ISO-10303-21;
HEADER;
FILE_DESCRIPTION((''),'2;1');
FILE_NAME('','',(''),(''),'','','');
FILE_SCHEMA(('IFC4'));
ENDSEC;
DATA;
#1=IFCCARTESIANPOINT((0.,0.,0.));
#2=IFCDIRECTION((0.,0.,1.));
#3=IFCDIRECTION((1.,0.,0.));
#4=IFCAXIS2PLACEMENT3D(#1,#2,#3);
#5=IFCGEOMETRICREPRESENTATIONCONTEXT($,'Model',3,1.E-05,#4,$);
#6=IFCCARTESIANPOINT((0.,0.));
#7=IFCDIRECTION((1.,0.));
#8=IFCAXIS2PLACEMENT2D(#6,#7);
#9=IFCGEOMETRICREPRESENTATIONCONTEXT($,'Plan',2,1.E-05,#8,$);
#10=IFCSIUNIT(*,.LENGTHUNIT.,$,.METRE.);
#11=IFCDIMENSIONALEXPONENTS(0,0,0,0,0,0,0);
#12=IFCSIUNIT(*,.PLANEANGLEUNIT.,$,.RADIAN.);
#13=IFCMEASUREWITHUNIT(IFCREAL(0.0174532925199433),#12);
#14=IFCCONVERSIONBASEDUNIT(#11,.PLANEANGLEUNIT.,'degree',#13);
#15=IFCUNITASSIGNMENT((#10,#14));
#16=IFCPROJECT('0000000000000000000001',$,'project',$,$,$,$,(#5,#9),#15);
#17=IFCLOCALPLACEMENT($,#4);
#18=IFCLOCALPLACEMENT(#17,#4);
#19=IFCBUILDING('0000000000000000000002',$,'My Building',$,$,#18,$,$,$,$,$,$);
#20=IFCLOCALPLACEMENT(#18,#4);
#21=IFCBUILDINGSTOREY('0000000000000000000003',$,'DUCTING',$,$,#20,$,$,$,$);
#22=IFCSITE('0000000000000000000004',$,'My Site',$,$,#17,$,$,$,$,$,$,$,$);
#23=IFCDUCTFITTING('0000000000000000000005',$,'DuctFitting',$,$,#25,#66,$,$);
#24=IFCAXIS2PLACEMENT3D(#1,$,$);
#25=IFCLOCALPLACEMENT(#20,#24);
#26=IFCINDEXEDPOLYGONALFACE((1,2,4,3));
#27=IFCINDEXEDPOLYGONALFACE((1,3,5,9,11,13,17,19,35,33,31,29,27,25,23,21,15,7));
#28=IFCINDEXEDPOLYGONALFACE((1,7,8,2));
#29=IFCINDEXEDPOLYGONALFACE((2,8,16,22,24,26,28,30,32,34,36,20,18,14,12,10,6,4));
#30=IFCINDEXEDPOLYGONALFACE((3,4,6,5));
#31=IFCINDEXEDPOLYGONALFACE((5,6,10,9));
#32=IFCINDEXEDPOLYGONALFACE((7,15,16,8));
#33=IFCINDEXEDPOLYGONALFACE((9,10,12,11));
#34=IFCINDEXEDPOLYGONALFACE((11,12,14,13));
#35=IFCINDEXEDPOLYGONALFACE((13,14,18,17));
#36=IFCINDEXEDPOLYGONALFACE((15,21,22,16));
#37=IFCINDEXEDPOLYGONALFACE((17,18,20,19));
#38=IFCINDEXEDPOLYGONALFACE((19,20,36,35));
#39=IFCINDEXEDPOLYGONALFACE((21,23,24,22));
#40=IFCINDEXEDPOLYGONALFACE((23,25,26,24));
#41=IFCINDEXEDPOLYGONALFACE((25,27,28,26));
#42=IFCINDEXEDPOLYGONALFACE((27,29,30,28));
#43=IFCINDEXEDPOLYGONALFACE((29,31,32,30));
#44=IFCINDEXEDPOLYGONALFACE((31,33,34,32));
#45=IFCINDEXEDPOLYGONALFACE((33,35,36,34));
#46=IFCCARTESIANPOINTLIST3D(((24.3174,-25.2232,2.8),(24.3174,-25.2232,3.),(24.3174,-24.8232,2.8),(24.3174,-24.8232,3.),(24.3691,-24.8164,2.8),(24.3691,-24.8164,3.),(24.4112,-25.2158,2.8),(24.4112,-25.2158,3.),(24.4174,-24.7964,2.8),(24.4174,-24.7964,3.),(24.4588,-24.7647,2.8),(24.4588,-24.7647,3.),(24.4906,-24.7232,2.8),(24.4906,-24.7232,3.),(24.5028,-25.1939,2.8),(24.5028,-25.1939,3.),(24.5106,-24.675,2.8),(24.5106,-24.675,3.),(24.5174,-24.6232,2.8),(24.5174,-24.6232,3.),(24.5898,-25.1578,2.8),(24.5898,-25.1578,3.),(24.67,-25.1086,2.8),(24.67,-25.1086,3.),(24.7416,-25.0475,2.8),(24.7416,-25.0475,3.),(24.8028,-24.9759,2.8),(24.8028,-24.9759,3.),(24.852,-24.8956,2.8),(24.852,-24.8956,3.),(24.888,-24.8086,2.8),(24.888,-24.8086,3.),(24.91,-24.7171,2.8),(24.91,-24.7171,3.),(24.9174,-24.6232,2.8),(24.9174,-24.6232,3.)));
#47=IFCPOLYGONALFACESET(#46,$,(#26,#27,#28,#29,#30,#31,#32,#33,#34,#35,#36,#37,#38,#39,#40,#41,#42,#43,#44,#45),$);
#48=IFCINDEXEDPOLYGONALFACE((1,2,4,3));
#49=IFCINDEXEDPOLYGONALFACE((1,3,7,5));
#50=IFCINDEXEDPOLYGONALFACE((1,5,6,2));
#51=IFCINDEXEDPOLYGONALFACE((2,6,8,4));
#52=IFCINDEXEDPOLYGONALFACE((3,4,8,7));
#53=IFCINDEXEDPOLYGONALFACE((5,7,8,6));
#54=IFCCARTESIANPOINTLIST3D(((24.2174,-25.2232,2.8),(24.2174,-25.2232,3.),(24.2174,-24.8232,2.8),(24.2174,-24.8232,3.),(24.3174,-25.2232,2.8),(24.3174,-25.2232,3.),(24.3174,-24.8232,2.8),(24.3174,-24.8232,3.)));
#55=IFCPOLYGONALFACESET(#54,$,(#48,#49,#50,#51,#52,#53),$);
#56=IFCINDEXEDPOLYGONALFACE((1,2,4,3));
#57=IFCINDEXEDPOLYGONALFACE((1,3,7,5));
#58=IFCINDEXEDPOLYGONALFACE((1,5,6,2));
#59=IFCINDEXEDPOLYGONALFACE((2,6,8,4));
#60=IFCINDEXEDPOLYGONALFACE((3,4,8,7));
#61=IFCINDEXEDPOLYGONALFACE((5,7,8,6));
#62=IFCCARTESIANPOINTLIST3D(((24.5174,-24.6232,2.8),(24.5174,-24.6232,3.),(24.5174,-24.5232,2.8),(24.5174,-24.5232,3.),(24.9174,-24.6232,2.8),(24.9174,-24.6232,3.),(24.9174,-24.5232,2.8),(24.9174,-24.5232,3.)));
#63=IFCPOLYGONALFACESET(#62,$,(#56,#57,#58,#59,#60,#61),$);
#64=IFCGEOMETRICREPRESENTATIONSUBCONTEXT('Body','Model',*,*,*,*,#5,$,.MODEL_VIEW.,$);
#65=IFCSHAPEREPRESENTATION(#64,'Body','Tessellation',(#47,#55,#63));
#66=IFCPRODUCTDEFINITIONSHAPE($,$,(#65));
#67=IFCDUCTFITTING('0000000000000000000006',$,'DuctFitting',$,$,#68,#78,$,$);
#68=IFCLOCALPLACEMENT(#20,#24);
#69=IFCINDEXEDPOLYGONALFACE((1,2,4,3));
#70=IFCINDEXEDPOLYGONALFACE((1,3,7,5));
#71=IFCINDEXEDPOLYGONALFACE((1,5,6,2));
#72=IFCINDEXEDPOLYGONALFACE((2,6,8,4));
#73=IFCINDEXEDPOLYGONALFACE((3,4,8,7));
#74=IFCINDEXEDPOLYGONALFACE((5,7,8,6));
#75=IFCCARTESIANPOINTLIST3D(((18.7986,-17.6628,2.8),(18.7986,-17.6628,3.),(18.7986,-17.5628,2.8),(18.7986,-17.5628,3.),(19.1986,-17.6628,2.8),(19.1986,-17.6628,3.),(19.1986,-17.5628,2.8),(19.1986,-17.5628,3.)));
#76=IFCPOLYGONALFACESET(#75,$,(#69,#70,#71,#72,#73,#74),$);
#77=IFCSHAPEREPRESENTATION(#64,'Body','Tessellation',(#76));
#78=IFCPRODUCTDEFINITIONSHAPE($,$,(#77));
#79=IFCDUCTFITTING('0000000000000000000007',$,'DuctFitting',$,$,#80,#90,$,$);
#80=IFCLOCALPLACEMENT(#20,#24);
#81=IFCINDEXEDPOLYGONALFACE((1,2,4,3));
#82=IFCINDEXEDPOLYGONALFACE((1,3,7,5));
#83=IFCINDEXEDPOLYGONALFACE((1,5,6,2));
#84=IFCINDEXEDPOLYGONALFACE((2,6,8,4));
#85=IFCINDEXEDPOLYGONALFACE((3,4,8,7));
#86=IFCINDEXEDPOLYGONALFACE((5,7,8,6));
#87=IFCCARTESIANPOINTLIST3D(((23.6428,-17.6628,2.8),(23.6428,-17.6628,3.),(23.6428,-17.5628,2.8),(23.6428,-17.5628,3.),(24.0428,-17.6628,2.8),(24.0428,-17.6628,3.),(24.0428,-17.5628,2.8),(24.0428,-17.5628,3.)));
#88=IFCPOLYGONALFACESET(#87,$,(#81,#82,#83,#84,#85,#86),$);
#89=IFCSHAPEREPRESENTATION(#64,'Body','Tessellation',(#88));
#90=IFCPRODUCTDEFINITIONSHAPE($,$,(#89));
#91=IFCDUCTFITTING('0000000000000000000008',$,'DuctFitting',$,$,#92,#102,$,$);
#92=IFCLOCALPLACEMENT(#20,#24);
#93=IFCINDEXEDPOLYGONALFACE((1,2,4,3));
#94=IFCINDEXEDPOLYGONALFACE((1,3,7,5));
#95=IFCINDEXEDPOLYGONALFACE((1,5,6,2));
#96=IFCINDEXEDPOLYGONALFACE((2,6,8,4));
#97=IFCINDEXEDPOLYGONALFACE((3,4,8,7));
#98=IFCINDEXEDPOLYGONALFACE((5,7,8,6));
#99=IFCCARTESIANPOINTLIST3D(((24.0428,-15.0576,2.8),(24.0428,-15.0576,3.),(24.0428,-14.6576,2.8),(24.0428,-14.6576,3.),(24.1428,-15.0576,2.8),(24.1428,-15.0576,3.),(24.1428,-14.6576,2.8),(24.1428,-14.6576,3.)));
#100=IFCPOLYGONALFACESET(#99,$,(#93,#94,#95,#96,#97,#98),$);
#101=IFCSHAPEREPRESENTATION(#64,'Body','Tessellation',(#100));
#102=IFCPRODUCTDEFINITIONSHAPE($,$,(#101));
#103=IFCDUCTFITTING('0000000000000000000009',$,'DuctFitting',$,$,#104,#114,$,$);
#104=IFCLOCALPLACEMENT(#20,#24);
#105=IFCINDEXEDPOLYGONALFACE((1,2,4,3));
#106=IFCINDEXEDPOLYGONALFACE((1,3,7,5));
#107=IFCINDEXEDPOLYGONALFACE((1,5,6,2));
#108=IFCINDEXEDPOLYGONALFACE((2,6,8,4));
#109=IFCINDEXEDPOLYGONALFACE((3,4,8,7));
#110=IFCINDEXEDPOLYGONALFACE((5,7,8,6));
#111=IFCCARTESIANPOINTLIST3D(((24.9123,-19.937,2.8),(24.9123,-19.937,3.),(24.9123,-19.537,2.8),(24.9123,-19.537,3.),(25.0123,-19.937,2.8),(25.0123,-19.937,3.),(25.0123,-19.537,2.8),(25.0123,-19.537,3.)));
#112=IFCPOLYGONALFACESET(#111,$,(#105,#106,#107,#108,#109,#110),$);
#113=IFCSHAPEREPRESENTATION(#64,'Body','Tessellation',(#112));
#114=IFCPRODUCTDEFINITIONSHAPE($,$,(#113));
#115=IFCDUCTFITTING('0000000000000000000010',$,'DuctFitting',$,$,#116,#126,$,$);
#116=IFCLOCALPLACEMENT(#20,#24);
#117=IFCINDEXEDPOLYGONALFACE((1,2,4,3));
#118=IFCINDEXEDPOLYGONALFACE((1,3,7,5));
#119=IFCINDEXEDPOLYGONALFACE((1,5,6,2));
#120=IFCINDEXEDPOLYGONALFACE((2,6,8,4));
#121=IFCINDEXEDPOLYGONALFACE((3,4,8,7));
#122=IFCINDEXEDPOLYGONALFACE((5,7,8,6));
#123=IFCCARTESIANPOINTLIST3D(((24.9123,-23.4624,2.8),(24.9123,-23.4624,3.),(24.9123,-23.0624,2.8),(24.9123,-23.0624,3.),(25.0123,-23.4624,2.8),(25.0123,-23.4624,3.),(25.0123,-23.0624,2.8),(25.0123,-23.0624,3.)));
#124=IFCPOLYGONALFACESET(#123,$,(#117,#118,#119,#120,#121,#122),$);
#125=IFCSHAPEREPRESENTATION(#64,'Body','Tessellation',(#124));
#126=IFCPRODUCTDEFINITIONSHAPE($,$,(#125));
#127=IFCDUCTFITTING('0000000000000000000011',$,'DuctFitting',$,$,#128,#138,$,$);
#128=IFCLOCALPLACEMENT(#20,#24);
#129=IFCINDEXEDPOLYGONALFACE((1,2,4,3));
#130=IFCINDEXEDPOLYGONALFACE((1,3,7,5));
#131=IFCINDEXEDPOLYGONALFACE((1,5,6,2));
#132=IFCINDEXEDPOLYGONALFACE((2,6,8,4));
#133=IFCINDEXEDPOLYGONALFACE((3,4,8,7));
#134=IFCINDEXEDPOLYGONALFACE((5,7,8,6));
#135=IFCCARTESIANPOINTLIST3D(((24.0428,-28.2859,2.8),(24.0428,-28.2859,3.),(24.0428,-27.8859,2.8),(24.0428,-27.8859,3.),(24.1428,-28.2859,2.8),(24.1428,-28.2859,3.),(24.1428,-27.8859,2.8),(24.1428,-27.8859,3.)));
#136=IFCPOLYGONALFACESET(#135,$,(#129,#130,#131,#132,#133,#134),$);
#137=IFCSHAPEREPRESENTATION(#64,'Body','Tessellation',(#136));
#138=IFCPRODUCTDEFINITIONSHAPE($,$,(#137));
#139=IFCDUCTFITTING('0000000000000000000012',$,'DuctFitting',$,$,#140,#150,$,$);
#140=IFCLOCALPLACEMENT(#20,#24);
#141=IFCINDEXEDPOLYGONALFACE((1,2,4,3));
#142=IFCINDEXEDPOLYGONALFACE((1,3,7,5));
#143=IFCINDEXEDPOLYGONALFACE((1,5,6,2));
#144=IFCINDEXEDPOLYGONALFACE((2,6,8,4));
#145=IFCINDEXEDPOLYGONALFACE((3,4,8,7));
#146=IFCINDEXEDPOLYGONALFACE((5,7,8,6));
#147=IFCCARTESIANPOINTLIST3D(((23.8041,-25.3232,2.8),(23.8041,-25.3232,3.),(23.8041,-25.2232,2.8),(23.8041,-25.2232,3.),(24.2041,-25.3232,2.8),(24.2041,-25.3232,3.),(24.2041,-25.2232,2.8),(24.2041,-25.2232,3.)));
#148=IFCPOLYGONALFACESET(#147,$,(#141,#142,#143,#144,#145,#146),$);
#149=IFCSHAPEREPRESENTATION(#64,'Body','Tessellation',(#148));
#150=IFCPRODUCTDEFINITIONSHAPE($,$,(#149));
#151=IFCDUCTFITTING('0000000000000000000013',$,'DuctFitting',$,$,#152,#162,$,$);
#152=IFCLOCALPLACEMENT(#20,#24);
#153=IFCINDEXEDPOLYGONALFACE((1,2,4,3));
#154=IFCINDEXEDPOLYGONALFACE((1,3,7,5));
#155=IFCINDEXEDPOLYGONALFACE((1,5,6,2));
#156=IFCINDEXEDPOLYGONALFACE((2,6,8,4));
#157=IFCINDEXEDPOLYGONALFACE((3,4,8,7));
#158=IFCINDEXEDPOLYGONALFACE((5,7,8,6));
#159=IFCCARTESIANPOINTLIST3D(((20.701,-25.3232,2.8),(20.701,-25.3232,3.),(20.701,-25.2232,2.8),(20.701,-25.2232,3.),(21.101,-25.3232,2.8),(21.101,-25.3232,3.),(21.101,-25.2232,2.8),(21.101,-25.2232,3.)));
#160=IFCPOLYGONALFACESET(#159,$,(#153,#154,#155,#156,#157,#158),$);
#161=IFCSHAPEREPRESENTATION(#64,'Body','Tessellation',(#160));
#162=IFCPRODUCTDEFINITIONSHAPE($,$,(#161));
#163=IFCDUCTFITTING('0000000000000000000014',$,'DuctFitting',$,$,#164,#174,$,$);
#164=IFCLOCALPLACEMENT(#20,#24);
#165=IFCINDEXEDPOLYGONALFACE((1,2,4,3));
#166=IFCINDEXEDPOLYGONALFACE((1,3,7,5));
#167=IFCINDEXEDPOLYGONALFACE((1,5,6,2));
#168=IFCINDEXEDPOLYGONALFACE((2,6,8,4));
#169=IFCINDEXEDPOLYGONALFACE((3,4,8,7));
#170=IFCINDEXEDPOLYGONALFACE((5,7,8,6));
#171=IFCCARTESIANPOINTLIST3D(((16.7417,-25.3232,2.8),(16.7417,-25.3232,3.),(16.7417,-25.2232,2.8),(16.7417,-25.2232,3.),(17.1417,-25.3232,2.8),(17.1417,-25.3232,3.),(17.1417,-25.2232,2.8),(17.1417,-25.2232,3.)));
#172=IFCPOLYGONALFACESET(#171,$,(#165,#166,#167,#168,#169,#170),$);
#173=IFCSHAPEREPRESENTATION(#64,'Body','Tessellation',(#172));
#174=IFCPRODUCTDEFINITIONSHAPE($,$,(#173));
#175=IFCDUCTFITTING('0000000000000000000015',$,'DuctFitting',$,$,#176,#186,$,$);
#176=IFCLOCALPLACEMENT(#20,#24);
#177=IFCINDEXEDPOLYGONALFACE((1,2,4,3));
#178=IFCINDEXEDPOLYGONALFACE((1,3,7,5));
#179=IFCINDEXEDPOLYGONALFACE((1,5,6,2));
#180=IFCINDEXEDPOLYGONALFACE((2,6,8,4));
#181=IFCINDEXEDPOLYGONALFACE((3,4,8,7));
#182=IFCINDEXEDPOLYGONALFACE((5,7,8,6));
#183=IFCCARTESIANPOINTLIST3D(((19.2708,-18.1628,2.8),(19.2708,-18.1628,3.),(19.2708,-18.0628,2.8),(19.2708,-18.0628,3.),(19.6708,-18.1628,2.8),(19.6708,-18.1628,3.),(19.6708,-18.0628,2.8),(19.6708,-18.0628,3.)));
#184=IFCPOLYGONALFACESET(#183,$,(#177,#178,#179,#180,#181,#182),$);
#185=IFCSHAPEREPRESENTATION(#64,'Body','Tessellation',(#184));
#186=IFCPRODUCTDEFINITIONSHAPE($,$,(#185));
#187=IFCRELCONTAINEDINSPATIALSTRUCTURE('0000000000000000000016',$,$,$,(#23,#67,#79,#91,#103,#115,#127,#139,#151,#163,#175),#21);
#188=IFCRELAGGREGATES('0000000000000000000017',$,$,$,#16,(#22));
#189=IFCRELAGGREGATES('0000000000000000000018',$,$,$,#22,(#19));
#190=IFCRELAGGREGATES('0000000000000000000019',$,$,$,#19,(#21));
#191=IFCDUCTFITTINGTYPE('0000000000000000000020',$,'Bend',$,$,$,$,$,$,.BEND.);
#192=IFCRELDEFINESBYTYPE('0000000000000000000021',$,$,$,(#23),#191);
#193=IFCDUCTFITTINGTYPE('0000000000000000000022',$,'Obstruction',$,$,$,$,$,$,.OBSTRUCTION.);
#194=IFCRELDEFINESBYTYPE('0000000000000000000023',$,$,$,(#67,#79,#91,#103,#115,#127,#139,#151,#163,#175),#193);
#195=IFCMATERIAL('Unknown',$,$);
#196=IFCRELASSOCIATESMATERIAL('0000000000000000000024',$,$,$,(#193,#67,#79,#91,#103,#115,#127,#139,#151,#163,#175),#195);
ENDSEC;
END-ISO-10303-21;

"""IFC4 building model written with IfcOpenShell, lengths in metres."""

from ifc_helpers import new_model, entity, si_unit, converted_unit, frame, origin_with_axes, origin_2d_with_axis, place, context, subcontext, project, spatial, line, arc, indexed_curve, rectangle, outline, extrude, source, transform, mapped, material, material_profile, profile_set, profile_usage, type_object, type_shapes, element, save


model = new_model("IFC4")

# Units and contexts
model_context = context("Model", 3, precision=1e-05, world=origin_with_axes())
plan_context = context("Plan", 2, precision=1e-05, world=origin_2d_with_axis())
body_context = subcontext(model_context, "Body", "Model", "MODEL_VIEW")
ifc_project = project(units=[si_unit("LENGTHUNIT", "METRE"), converted_unit("PLANEANGLEUNIT", "degree", entity("IfcReal", 0.0174532925199433), si_unit("PLANEANGLEUNIT", "RADIAN"), dimensions=[0, 0, 0, 0, 0, 0, 0])], contexts=[model_context, plan_context])

# Site, building, storey
site_placement = place(None, origin_with_axes())
site = spatial("IfcSite", under=ifc_project, at=site_placement, Name="My Site")
building_placement = place(site_placement, origin_with_axes())
building = spatial("IfcBuilding", under=site, at=building_placement, Name="My Building")
storey_placement = place(building_placement, origin_with_axes())
storey = spatial("IfcBuildingStorey", under=building, at=storey_placement, Name="DUCTING")

# Shared definitions
ifc_material = material(Name="Unknown")

# Duct fittings
duct_fitting_type_1 = type_object("IfcDuctFittingType", Name="Bend", PredefinedType="BEND")
shared_shape = source(origin_with_axes(), body_context, "Body", "SweptSolid", [
    extrude(outline(indexed_curve([(-0.2, 0.0), (-0.2586, -0.1414), (-0.4, -0.2), (-0.4, -0.6), (0.0243, -0.4243), (0.2, 0.0)], segments=[arc(1, 2, 3), line(3, 4), arc(4, 5, 6), line(6, 1)])), frame((0.0, -0.1, -0.1), z_axis=(0.0, -1.0, 0.0), x_axis=(1.0, 0.0, 0.0)), (0.0, 0.0, -1.0), 0.2),
    extrude(rectangle(XDim=0.4, YDim=0.2), origin_with_axes(), (0.0, 0.0, -1.0), 0.1),
    extrude(rectangle(XDim=0.4, YDim=0.2), frame((-0.4, 0.0, -0.5), z_axis=(-1.0, 0.0, 0.0), x_axis=(0.0, 0.0, -1.0)), (0.0, 0.0, 1.0), 0.1),
])
type_shapes(duct_fitting_type_1, [shared_shape])
for number, where, z_axis, x_axis, name in (
    (1, (24.2174, -25.0232, 2.9), (-1.0, 0.0, 0.0), (0.0, -1.0, 0.0), "DuctFitting"),
):
    element("IfcDuctFitting", number, at=place(storey_placement, frame(where, z_axis=z_axis, x_axis=x_axis)), inside=storey, type_object=duct_fitting_type_1, Name=name, context=body_context, shape_type="MappedRepresentation", body=[
        mapped(shared_shape, transform((0.0, 0.0, 0.0), x_axis=(1.0, 0.0, 0.0), y_axis=(0.0, 1.0, 0.0), z_axis=(0.0, 0.0, 1.0), scale=1.0)),
    ])
ifc_material_profile_1 = material_profile(ifc_material, rectangle(XDim=0.4, YDim=0.2))
ifc_profile_set_1 = profile_set([ifc_material_profile_1])
ifc_profile_usage_1 = profile_usage(ifc_profile_set_1, cardinal=5)
duct_fitting_type_2 = type_object("IfcDuctFittingType", Name="Obstruction", PredefinedType="OBSTRUCTION", material=ifc_profile_set_1)
duct_fitting_1_placement = place(storey_placement, frame((18.9986, -17.6628, 2.9), z_axis=(0.0, 1.0, 0.0), x_axis=(-1.0, 0.0, 0.0)))
element("IfcDuctFitting", 2, at=duct_fitting_1_placement, inside=storey, type_object=duct_fitting_type_2, material=ifc_profile_usage_1, Name="DuctFitting", context=body_context, shape_type="SweptSolid", body=[
    extrude(rectangle(XDim=0.4, YDim=0.2), origin_with_axes(), (0.0, 0.0, 1.0), 0.1),
])
ifc_profile_usage_2 = profile_usage(ifc_profile_set_1, cardinal=5)
duct_fitting_2_placement = place(storey_placement, frame((23.8428, -17.6628, 2.9), z_axis=(0.0, 1.0, 0.0), x_axis=(-1.0, 0.0, 0.0)))
element("IfcDuctFitting", 3, at=duct_fitting_2_placement, inside=storey, type_object=duct_fitting_type_2, material=ifc_profile_usage_2, Name="DuctFitting", context=body_context, shape_type="SweptSolid", body=[
    extrude(rectangle(XDim=0.4, YDim=0.2), origin_with_axes(), (0.0, 0.0, 1.0), 0.1),
])
ifc_profile_usage_3 = profile_usage(ifc_profile_set_1, cardinal=5)
duct_fitting_3_placement = place(storey_placement, frame((24.0428, -14.8576, 2.9), z_axis=(1.0, 0.0, 0.0), x_axis=(0.0, 1.0, 0.0)))
element("IfcDuctFitting", 4, at=duct_fitting_3_placement, inside=storey, type_object=duct_fitting_type_2, material=ifc_profile_usage_3, Name="DuctFitting", context=body_context, shape_type="SweptSolid", body=[
    extrude(rectangle(XDim=0.4, YDim=0.2), origin_with_axes(), (0.0, 0.0, 1.0), 0.1),
])
ifc_profile_usage_4 = profile_usage(ifc_profile_set_1, cardinal=5)
duct_fitting_4_placement = place(storey_placement, frame((24.9123, -19.737, 2.9), z_axis=(1.0, 0.0, 0.0), x_axis=(0.0, 1.0, 0.0)))
element("IfcDuctFitting", 5, at=duct_fitting_4_placement, inside=storey, type_object=duct_fitting_type_2, material=ifc_profile_usage_4, Name="DuctFitting", context=body_context, shape_type="SweptSolid", body=[
    extrude(rectangle(XDim=0.4, YDim=0.2), origin_with_axes(), (0.0, 0.0, 1.0), 0.1),
])
ifc_profile_usage_5 = profile_usage(ifc_profile_set_1, cardinal=5)
duct_fitting_5_placement = place(storey_placement, frame((24.9123, -23.2624, 2.9), z_axis=(1.0, 0.0, 0.0), x_axis=(0.0, 1.0, 0.0)))
element("IfcDuctFitting", 6, at=duct_fitting_5_placement, inside=storey, type_object=duct_fitting_type_2, material=ifc_profile_usage_5, Name="DuctFitting", context=body_context, shape_type="SweptSolid", body=[
    extrude(rectangle(XDim=0.4, YDim=0.2), origin_with_axes(), (0.0, 0.0, 1.0), 0.1),
])
ifc_profile_usage_6 = profile_usage(ifc_profile_set_1, cardinal=5)
duct_fitting_6_placement = place(storey_placement, frame((24.0428, -28.0859, 2.9), z_axis=(1.0, 0.0, 0.0), x_axis=(0.0, 1.0, 0.0)))
element("IfcDuctFitting", 7, at=duct_fitting_6_placement, inside=storey, type_object=duct_fitting_type_2, material=ifc_profile_usage_6, Name="DuctFitting", context=body_context, shape_type="SweptSolid", body=[
    extrude(rectangle(XDim=0.4, YDim=0.2), origin_with_axes(), (0.0, 0.0, 1.0), 0.1),
])
ifc_profile_usage_7 = profile_usage(ifc_profile_set_1, cardinal=5)
duct_fitting_7_placement = place(storey_placement, frame((24.0041, -25.2232, 2.9), z_axis=(0.0, -1.0, 0.0), x_axis=(1.0, 0.0, 0.0)))
element("IfcDuctFitting", 8, at=duct_fitting_7_placement, inside=storey, type_object=duct_fitting_type_2, material=ifc_profile_usage_7, Name="DuctFitting", context=body_context, shape_type="SweptSolid", body=[
    extrude(rectangle(XDim=0.4, YDim=0.2), origin_with_axes(), (0.0, 0.0, 1.0), 0.1),
])
ifc_profile_usage_8 = profile_usage(ifc_profile_set_1, cardinal=5)
duct_fitting_8_placement = place(storey_placement, frame((20.901, -25.2232, 2.9), z_axis=(0.0, -1.0, 0.0), x_axis=(1.0, 0.0, 0.0)))
element("IfcDuctFitting", 9, at=duct_fitting_8_placement, inside=storey, type_object=duct_fitting_type_2, material=ifc_profile_usage_8, Name="DuctFitting", context=body_context, shape_type="SweptSolid", body=[
    extrude(rectangle(XDim=0.4, YDim=0.2), origin_with_axes(), (0.0, 0.0, 1.0), 0.1),
])
ifc_profile_usage_9 = profile_usage(ifc_profile_set_1, cardinal=5)
duct_fitting_9_placement = place(storey_placement, frame((16.9417, -25.2232, 2.9), z_axis=(0.0, -1.0, 0.0), x_axis=(1.0, 0.0, 0.0)))
element("IfcDuctFitting", 10, at=duct_fitting_9_placement, inside=storey, type_object=duct_fitting_type_2, material=ifc_profile_usage_9, Name="DuctFitting", context=body_context, shape_type="SweptSolid", body=[
    extrude(rectangle(XDim=0.4, YDim=0.2), origin_with_axes(), (0.0, 0.0, 1.0), 0.1),
])
ifc_profile_usage_10 = profile_usage(ifc_profile_set_1, cardinal=5)
duct_fitting_10_placement = place(storey_placement, frame((19.4708, -18.0628, 2.9), z_axis=(0.0, -1.0, 0.0), x_axis=(1.0, 0.0, 0.0)))
element("IfcDuctFitting", 11, at=duct_fitting_10_placement, inside=storey, type_object=duct_fitting_type_2, material=ifc_profile_usage_10, Name="DuctFitting", context=body_context, shape_type="SweptSolid", body=[
    extrude(rectangle(XDim=0.4, YDim=0.2), origin_with_axes(), (0.0, 0.0, 1.0), 0.1),
])

save(model, "model.ifc")
